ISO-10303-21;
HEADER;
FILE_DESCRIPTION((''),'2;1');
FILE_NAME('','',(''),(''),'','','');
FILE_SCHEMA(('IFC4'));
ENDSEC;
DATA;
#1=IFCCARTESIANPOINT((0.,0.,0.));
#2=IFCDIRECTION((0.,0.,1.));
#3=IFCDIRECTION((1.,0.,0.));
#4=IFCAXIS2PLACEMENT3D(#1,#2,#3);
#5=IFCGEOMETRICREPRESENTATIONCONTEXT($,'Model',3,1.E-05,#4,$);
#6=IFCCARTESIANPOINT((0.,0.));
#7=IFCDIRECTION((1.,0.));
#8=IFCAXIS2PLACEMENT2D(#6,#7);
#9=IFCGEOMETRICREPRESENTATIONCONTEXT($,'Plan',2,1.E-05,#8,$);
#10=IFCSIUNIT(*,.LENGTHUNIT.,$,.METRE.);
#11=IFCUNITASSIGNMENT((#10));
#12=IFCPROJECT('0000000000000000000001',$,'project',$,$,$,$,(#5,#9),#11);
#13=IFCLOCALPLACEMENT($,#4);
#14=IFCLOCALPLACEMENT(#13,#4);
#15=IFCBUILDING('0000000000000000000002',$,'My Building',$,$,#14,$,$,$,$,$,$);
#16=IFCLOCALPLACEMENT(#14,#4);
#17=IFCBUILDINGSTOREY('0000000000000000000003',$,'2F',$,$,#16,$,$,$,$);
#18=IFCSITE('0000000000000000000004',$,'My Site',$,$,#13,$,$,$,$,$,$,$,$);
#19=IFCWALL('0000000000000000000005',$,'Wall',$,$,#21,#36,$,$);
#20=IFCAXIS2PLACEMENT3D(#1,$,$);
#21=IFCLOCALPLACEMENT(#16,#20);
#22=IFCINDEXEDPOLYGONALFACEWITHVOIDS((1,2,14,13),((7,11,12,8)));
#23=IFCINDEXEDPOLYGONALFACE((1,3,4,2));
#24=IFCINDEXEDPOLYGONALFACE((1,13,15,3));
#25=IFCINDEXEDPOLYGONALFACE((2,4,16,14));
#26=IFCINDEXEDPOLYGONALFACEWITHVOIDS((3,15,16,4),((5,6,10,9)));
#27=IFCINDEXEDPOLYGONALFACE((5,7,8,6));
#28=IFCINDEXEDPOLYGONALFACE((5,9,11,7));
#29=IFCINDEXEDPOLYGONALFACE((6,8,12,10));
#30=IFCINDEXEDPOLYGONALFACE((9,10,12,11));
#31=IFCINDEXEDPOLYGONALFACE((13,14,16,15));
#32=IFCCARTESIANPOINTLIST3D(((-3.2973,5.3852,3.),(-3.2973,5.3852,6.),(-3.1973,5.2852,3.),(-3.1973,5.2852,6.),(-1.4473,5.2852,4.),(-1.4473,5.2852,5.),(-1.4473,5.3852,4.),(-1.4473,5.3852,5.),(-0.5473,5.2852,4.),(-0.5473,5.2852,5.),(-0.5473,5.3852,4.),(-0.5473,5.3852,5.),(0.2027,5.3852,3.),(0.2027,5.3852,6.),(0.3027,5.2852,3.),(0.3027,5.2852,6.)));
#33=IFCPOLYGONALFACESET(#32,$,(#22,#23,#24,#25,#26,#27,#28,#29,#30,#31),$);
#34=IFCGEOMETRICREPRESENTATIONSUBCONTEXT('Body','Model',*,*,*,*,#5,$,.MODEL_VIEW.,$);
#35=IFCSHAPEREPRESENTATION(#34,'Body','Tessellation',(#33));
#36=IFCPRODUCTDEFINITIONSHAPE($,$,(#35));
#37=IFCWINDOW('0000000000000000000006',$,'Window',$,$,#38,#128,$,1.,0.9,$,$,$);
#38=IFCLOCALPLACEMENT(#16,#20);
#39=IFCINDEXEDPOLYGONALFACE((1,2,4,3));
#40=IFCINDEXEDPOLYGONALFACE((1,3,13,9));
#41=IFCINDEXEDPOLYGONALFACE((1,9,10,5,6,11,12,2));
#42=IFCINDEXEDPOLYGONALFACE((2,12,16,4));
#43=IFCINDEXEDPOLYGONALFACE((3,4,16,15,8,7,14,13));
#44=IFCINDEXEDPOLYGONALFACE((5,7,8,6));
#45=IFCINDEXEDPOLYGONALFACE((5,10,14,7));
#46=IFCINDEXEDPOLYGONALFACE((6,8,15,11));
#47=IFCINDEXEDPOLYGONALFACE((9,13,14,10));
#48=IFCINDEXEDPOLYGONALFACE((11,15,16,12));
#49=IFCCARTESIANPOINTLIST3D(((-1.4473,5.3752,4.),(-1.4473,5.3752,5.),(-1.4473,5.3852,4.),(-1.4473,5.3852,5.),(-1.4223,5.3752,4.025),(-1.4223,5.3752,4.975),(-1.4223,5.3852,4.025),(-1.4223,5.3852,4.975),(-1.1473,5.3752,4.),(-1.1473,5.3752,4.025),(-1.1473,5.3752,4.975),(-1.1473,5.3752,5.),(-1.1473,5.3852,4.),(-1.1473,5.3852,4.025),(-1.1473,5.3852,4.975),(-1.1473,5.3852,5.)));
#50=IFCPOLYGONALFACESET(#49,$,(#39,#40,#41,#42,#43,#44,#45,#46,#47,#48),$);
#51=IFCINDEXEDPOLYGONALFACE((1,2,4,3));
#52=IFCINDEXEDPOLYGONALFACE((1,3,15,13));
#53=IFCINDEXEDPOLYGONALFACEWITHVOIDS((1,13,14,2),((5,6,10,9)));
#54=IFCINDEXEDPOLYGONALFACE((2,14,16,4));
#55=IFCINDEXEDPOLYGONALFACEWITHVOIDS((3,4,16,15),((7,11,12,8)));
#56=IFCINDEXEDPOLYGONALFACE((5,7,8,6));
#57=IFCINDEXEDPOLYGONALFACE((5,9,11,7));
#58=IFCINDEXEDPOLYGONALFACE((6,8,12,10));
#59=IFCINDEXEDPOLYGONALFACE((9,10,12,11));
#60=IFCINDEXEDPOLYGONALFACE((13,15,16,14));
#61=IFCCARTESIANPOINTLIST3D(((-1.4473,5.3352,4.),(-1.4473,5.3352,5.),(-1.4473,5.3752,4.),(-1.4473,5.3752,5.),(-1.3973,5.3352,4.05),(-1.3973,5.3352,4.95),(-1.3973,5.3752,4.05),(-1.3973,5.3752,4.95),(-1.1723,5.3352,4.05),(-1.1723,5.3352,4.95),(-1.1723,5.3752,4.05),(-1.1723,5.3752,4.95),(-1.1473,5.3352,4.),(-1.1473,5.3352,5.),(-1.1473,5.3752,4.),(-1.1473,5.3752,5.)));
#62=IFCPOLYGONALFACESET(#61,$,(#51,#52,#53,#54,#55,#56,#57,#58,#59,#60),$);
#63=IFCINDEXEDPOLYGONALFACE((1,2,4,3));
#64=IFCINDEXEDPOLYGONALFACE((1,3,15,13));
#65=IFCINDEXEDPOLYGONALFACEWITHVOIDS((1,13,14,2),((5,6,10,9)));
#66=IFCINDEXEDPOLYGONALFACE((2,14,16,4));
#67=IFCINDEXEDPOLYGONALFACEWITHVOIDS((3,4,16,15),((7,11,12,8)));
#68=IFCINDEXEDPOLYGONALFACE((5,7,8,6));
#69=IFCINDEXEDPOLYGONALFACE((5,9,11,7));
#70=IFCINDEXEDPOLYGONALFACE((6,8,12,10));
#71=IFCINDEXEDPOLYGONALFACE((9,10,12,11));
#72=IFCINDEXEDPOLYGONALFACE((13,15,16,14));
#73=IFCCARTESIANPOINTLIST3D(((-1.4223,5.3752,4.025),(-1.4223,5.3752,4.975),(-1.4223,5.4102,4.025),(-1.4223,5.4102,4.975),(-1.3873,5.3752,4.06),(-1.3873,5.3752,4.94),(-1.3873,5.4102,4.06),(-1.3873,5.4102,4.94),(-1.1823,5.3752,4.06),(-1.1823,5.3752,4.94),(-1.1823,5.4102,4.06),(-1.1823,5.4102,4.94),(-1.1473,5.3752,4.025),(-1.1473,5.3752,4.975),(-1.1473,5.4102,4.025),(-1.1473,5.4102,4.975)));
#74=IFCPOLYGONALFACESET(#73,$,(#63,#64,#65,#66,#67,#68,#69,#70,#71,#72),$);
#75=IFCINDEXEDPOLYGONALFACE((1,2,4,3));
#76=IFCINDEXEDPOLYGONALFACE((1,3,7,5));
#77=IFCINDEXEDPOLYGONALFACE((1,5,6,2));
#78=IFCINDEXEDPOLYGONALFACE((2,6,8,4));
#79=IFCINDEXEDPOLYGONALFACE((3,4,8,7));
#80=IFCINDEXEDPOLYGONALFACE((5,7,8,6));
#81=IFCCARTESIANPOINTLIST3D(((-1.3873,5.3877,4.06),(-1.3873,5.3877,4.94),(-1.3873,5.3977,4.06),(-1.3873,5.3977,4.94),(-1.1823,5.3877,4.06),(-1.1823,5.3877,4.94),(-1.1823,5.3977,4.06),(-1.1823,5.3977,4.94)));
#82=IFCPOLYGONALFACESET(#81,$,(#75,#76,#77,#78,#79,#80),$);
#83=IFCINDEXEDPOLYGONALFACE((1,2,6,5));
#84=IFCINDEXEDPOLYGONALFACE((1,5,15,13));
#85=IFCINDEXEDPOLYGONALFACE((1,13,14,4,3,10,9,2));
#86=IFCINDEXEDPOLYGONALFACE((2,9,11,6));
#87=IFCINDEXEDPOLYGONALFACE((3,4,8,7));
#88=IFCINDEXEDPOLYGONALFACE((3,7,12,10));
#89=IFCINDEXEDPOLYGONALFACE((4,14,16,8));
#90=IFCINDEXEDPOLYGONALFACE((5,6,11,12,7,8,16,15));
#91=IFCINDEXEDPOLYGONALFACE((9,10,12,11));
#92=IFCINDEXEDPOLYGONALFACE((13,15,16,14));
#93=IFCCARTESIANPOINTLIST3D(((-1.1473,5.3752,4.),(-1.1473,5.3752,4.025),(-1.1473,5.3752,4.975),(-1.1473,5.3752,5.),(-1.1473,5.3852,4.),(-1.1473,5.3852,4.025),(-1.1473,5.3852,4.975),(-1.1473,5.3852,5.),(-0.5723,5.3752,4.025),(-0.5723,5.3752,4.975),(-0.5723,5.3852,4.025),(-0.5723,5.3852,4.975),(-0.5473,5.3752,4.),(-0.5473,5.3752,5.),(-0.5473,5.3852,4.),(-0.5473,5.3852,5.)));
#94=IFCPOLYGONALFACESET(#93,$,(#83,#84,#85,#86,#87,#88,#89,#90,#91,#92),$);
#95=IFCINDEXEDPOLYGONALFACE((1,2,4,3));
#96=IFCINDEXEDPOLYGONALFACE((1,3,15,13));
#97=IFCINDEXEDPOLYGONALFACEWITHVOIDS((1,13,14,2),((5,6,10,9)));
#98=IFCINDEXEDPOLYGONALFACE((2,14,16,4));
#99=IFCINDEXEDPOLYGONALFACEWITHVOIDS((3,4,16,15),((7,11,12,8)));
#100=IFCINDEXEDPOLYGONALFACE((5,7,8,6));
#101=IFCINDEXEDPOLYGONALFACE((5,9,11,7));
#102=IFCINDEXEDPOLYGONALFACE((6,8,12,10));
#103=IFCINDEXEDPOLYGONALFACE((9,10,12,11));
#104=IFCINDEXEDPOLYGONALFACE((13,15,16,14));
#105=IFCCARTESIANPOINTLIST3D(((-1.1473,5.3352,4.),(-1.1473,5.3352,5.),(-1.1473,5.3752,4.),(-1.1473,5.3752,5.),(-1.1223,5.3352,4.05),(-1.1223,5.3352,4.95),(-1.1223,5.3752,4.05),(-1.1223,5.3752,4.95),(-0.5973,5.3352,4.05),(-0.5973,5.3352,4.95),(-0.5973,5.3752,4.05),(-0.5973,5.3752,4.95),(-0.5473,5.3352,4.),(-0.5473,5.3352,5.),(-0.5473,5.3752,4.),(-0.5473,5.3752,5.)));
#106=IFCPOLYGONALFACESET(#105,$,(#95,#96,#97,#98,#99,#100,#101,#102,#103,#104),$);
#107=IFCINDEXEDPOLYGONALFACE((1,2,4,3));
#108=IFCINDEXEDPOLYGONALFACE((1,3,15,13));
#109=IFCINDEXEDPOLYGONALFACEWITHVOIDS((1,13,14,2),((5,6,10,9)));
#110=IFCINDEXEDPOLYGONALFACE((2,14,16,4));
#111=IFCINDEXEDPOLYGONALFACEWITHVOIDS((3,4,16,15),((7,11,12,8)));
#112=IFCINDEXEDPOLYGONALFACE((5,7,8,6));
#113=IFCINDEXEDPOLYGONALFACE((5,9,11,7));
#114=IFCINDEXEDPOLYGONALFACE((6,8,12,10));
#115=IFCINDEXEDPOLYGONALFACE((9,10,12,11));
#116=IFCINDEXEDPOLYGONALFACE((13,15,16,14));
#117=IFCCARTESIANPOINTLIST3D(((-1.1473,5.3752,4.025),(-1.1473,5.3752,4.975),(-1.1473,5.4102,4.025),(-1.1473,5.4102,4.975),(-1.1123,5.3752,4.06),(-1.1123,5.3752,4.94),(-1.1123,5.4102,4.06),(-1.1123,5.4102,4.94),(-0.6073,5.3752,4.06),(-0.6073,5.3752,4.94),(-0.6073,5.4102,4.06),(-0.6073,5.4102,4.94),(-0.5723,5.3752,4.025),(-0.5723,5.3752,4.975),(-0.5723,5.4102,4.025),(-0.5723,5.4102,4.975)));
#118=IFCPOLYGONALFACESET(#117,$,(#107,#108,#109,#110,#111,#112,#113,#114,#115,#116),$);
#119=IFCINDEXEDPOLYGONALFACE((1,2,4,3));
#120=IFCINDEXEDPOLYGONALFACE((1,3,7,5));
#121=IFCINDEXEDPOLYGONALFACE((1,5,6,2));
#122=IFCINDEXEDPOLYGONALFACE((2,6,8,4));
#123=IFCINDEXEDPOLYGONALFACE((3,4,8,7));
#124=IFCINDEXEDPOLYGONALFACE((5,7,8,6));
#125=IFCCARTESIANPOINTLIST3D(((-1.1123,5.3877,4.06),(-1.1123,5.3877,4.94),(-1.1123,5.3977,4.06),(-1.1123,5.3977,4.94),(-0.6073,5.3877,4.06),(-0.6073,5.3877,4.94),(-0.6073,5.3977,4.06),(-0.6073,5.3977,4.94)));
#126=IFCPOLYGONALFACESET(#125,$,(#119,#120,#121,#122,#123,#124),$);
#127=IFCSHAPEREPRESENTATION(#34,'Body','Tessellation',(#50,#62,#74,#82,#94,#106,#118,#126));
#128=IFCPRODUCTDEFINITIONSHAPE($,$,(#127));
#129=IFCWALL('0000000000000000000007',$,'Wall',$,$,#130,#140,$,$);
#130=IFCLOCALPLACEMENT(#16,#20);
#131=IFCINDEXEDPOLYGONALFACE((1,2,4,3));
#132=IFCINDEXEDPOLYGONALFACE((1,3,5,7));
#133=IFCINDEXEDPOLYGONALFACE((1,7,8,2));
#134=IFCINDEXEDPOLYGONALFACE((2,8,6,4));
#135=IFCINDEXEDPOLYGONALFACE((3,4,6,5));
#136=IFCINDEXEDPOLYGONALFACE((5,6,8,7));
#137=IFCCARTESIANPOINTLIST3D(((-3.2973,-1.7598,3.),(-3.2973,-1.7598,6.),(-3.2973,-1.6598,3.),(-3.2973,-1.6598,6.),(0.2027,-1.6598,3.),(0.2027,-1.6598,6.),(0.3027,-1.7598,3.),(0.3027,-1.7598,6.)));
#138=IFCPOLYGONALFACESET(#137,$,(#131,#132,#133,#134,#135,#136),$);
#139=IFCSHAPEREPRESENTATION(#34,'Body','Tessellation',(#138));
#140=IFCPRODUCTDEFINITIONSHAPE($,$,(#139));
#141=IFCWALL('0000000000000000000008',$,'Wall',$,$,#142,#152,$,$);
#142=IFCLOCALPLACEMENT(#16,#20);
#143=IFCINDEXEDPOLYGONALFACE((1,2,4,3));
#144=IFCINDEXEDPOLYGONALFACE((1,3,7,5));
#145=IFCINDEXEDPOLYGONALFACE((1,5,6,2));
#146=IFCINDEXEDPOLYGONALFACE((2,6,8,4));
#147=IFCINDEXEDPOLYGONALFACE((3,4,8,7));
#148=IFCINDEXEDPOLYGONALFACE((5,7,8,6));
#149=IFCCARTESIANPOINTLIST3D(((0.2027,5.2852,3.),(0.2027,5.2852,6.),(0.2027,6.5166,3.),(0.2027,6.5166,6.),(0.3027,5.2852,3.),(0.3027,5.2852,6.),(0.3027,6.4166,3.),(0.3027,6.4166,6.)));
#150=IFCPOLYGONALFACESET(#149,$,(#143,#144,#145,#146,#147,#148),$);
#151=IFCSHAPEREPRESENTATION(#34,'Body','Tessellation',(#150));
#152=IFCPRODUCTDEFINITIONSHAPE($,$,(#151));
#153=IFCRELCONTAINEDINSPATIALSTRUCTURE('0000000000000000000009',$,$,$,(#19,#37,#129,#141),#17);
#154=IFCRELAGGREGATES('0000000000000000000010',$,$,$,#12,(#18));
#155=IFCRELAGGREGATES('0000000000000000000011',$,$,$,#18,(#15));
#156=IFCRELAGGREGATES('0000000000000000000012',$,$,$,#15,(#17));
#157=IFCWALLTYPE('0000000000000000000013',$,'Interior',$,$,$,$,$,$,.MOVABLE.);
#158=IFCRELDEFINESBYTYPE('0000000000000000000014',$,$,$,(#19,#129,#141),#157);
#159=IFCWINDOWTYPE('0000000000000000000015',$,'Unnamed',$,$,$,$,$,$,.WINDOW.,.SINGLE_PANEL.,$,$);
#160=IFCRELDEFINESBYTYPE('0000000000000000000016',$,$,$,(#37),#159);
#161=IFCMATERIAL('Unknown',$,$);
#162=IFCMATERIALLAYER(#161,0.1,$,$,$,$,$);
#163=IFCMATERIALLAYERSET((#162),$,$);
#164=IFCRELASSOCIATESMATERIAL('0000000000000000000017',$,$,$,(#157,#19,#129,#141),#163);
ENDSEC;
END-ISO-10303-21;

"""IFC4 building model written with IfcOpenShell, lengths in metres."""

from ifc_helpers import new_model, entity, si_unit, frame, origin_with_axes, origin_2d_with_axis, place, context, subcontext, project, spatial, line, indexed_curve, outline, extrude, shape, source, transform, mapped, material, layer, layer_set, layer_usage, type_object, type_shapes, element, fill, save


model = new_model("IFC4")

# Units and contexts
model_context = context("Model", 3, precision=1e-05, world=origin_with_axes())
plan_context = context("Plan", 2, precision=1e-05, world=origin_2d_with_axis())
body_context_1 = subcontext(model_context, "Body", "Model", "MODEL_VIEW")
body_context_2 = subcontext(plan_context, "Body", "Plan", "PLAN_VIEW")
ifc_project = project(units=[si_unit("LENGTHUNIT", "METRE")], contexts=[model_context, plan_context])

# Site, building, storey
site_placement = place(None, origin_with_axes())
site = spatial("IfcSite", under=ifc_project, at=site_placement, Name="My Site")
building_placement = place(site_placement, origin_with_axes())
building = spatial("IfcBuilding", under=site, at=building_placement, Name="My Building")
storey_placement = place(building_placement, origin_with_axes())
storey = spatial("IfcBuildingStorey", under=building, at=storey_placement, Name="2F")

# Shared definitions
ifc_material = material(Name="Unknown")

# Shared definitions
ifc_layer_1 = layer(ifc_material, 0.1)
ifc_layer_set_1 = layer_set([ifc_layer_1])
wall_type = type_object("IfcWallType", Name="Interior", PredefinedType="MOVABLE", material=ifc_layer_set_1)

# Wall, opening, window
ifc_layer_usage_1 = layer_usage(ifc_layer_set_1, "AXIS2", "POSITIVE", 0.0)
wall_1_placement = place(storey_placement, frame((0.2027, 5.3852, 3.0), z_axis=(0.0, 0.0, 1.0), x_axis=(-1.0, 0.0, 0.0)))
wall_1 = element("IfcWall", 1, at=wall_1_placement, inside=storey, type_object=wall_type, material=ifc_layer_usage_1, Name="Wall", context=body_context_1, shape_type="SweptSolid", body=[
    extrude(outline(indexed_curve([(0.0, 0.0), (-0.1, 0.1), (3.4, 0.1), (3.5, 0.0)], segments=[line(1, 2, 3, 4, 1)])), origin_with_axes(), (0.0, 0.0, 1.0), 3.0),
])
shared_shape_1 = source(origin_with_axes(), body_context_1, "Body", "SweptSolid", [
    extrude(outline(indexed_curve([(0.0, 0.0), (0.9, 0.0), (0.9, 1.0), (0.0, 1.0)], segments=[line(1, 2, 3, 4, 1)])), frame((0.0, -0.6, 0.0), z_axis=(0.0, -1.0, 0.0), x_axis=(1.0, 0.0, 0.0)), (0.0, 0.0, -1.0), 1.2),
])
opening_1_placement = place(wall_1_placement, frame((1.65, 0.1, 1.0), z_axis=(0.0, 0.0, 1.0), x_axis=(-1.0, 0.0, 0.0)))
opening_1 = element("IfcOpeningElement", 2, at=opening_1_placement, cuts=wall_1, PredefinedType="OPENING", context=body_context_1, shape_type="MappedRepresentation", body=[
    mapped(shared_shape_1, transform((0.0, 0.0, 0.0), x_axis=(1.0, 0.0, 0.0), y_axis=(0.0, 1.0, 0.0), z_axis=(0.0, 0.0, 1.0), scale=1.0)),
])
window_type = type_object("IfcWindowType", Name="Unnamed", PartitioningType="SINGLE_PANEL", PredefinedType="WINDOW")
shared_shape_2 = source(origin_with_axes(), body_context_1, "Body", "SweptSolid", [
    extrude(outline(indexed_curve([(0.3, 0.0), (0.0, 0.0), (0.0, 1.0), (0.3, 1.0), (0.3, 0.975), (0.025, 0.975), (0.025, 0.025), (0.3, 0.025)], segments=[line(1, 2, 3, 4, 5, 6, 7, 8, 1)])), frame((0.0, 0.09, 0.0), z_axis=(0.0, -1.0, 0.0), x_axis=(1.0, 0.0, 0.0)), (0.0, 0.0, -1.0), 0.01),
    extrude(outline(indexed_curve([(0.0, 0.0), (0.3, 0.0), (0.3, 1.0), (0.0, 1.0)], segments=[line(1, 2, 3, 4, 1)]), holes=[indexed_curve([(0.05, 0.05), (0.275, 0.05), (0.275, 0.95), (0.05, 0.95)], segments=[line(1, 2, 3, 4, 1)])]), frame((0.0, 0.05, 0.0), z_axis=(0.0, -1.0, 0.0), x_axis=(1.0, 0.0, 0.0)), (0.0, 0.0, -1.0), 0.04),
    extrude(outline(indexed_curve([(0.0, 0.0), (0.275, 0.0), (0.275, 0.95), (0.0, 0.95)], segments=[line(1, 2, 3, 4, 1)]), holes=[indexed_curve([(0.035, 0.035), (0.24, 0.035), (0.24, 0.915), (0.035, 0.915)], segments=[line(1, 2, 3, 4, 1)])]), frame((0.025, 0.09, 0.025), z_axis=(0.0, -1.0, 0.0), x_axis=(1.0, 0.0, 0.0)), (0.0, 0.0, -1.0), 0.035),
    extrude(outline(indexed_curve([(0.035, 0.035), (0.24, 0.035), (0.24, 0.915), (0.035, 0.915)], segments=[line(1, 2, 3, 4, 1)])), frame((0.025, 0.1025, 0.025), z_axis=(0.0, -1.0, 0.0), x_axis=(1.0, 0.0, 0.0)), (0.0, 0.0, -1.0), 0.01),
    extrude(outline(indexed_curve([(0.0, 1.0), (0.6, 1.0), (0.6, 0.0), (0.0, 0.0), (0.0, 0.025), (0.575, 0.025), (0.575, 0.975), (0.0, 0.975)], segments=[line(1, 2, 3, 4, 5, 6, 7, 8, 1)])), frame((0.3, 0.09, 0.0), z_axis=(0.0, -1.0, 0.0), x_axis=(1.0, 0.0, 0.0)), (0.0, 0.0, -1.0), 0.01),
    extrude(outline(indexed_curve([(0.0, 0.0), (0.6, 0.0), (0.6, 1.0), (0.0, 1.0)], segments=[line(1, 2, 3, 4, 1)]), holes=[indexed_curve([(0.025, 0.05), (0.55, 0.05), (0.55, 0.95), (0.025, 0.95)], segments=[line(1, 2, 3, 4, 1)])]), frame((0.3, 0.05, 0.0), z_axis=(0.0, -1.0, 0.0), x_axis=(1.0, 0.0, 0.0)), (0.0, 0.0, -1.0), 0.04),
    extrude(outline(indexed_curve([(0.0, 0.0), (0.575, 0.0), (0.575, 0.95), (0.0, 0.95)], segments=[line(1, 2, 3, 4, 1)]), holes=[indexed_curve([(0.035, 0.035), (0.54, 0.035), (0.54, 0.915), (0.035, 0.915)], segments=[line(1, 2, 3, 4, 1)])]), frame((0.3, 0.09, 0.025), z_axis=(0.0, -1.0, 0.0), x_axis=(1.0, 0.0, 0.0)), (0.0, 0.0, -1.0), 0.035),
    extrude(outline(indexed_curve([(0.035, 0.035), (0.54, 0.035), (0.54, 0.915), (0.035, 0.915)], segments=[line(1, 2, 3, 4, 1)])), frame((0.3, 0.1025, 0.025), z_axis=(0.0, -1.0, 0.0), x_axis=(1.0, 0.0, 0.0)), (0.0, 0.0, -1.0), 0.01),
])
shared_shape_3 = source(origin_with_axes(), body_context_2, "Body", "Curve2D", [
    entity("IfcIndexedPolyCurve", entity("IfcCartesianPointList2D", [[0.05, 0.05], [0.275, 0.05]])),
    entity("IfcIndexedPolyCurve", entity("IfcCartesianPointList2D", [[0.0, 0.1], [0.025, 0.1], [0.025, 0.09], [0.05, 0.09], [0.05, 0.05], [0.0, 0.05]]), [entity("IfcLineIndex", [1, 2, 3, 4, 5, 6, 1])]),
    entity("IfcIndexedPolyCurve", entity("IfcCartesianPointList2D", [[0.3, 0.1], [0.3, 0.1], [0.3, 0.09], [0.275, 0.09], [0.275, 0.05], [0.3, 0.05]])),
    entity("IfcIndexedPolyCurve", entity("IfcCartesianPointList2D", [[0.025, 0.09], [0.06, 0.09], [0.06, 0.125], [0.025, 0.125]]), [entity("IfcLineIndex", [1, 2, 3, 4, 1])]),
    entity("IfcIndexedPolyCurve", entity("IfcCartesianPointList2D", [[0.3, 0.09], [0.265, 0.09], [0.265, 0.125], [0.3, 0.125]]), [entity("IfcLineIndex", [1, 2, 3, 4, 1])]),
    entity("IfcIndexedPolyCurve", entity("IfcCartesianPointList2D", [[0.06, 0.09], [0.265, 0.09]])),
    entity("IfcIndexedPolyCurve", entity("IfcCartesianPointList2D", [[0.06, 0.125], [0.265, 0.125]])),
    entity("IfcIndexedPolyCurve", entity("IfcCartesianPointList2D", [[0.06, 0.1075], [0.265, 0.1075]])),
    entity("IfcIndexedPolyCurve", entity("IfcCartesianPointList2D", [[0.325, 0.05], [0.85, 0.05]])),
    entity("IfcIndexedPolyCurve", entity("IfcCartesianPointList2D", [[0.3, 0.1], [0.3, 0.1], [0.3, 0.09], [0.325, 0.09], [0.325, 0.05], [0.3, 0.05]])),
    entity("IfcIndexedPolyCurve", entity("IfcCartesianPointList2D", [[0.9, 0.1], [0.875, 0.1], [0.875, 0.09], [0.85, 0.09], [0.85, 0.05], [0.9, 0.05]]), [entity("IfcLineIndex", [1, 2, 3, 4, 5, 6, 1])]),
    entity("IfcIndexedPolyCurve", entity("IfcCartesianPointList2D", [[0.3, 0.09], [0.335, 0.09], [0.335, 0.125], [0.3, 0.125]]), [entity("IfcLineIndex", [1, 2, 3, 4, 1])]),
    entity("IfcIndexedPolyCurve", entity("IfcCartesianPointList2D", [[0.875, 0.09], [0.84, 0.09], [0.84, 0.125], [0.875, 0.125]]), [entity("IfcLineIndex", [1, 2, 3, 4, 1])]),
    entity("IfcIndexedPolyCurve", entity("IfcCartesianPointList2D", [[0.335, 0.09], [0.84, 0.09]])),
    entity("IfcIndexedPolyCurve", entity("IfcCartesianPointList2D", [[0.335, 0.125], [0.84, 0.125]])),
    entity("IfcIndexedPolyCurve", entity("IfcCartesianPointList2D", [[0.335, 0.1075], [0.84, 0.1075]])),
])
type_shapes(window_type, [shared_shape_2, shared_shape_3])
window_1_placement = place(opening_1_placement, frame((0.0, 0.0, 0.0), z_axis=(0.0, 0.0, 1.0), x_axis=(1.0, 0.0, 0.0)))
window_1 = element("IfcWindow", 3, at=window_1_placement, inside=storey, type_object=window_type, Name="Window", OverallHeight=1.0, OverallWidth=0.9, shapes=[
    shape(body_context_1, "Body", "MappedRepresentation", [mapped(shared_shape_2, transform((0.0, 0.0, 0.0), x_axis=(1.0, 0.0, 0.0), y_axis=(0.0, 1.0, 0.0), z_axis=(0.0, 0.0, 1.0), scale=1.0))]),
    shape(body_context_2, "Body", "MappedRepresentation", [mapped(shared_shape_3, transform((0.0, 0.0, 0.0), x_axis=(1.0, 0.0, 0.0), y_axis=(0.0, 1.0, 0.0), z_axis=(0.0, 0.0, 1.0), scale=1.0))]),
])
fill(opening_1, window_1)

# Walls
ifc_layer_usage_2 = layer_usage(ifc_layer_set_1, "AXIS2", "POSITIVE", 0.0)
wall_2_placement = place(storey_placement, frame((-3.2973, -1.7598, 3.0), z_axis=(0.0, 0.0, 1.0), x_axis=(1.0, 0.0, 0.0)))
element("IfcWall", 4, at=wall_2_placement, inside=storey, type_object=wall_type, material=ifc_layer_usage_2, Name="Wall", context=body_context_1, shape_type="SweptSolid", body=[
    extrude(outline(indexed_curve([(0.0, 0.0), (0.0, 0.1), (3.5, 0.1), (3.6, 0.0)], segments=[line(1, 2, 3, 4, 1)])), origin_with_axes(), (0.0, 0.0, 1.0), 3.0),
])
ifc_layer_usage_3 = layer_usage(ifc_layer_set_1, "AXIS2", "POSITIVE", 0.0)
wall_3_placement = place(storey_placement, frame((0.3027, 5.2852, 3.0), z_axis=(0.0, 0.0, 1.0), x_axis=(0.0, 1.0, 0.0)))
element("IfcWall", 5, at=wall_3_placement, inside=storey, type_object=wall_type, material=ifc_layer_usage_3, Name="Wall", context=body_context_1, shape_type="SweptSolid", body=[
    extrude(outline(indexed_curve([(0.0, 0.0), (0.0, 0.1), (1.2314, 0.1), (1.1314, 0.0)], segments=[line(1, 2, 3, 4, 1)])), origin_with_axes(), (0.0, 0.0, 1.0), 3.0),
])

save(model, "model.ifc")
